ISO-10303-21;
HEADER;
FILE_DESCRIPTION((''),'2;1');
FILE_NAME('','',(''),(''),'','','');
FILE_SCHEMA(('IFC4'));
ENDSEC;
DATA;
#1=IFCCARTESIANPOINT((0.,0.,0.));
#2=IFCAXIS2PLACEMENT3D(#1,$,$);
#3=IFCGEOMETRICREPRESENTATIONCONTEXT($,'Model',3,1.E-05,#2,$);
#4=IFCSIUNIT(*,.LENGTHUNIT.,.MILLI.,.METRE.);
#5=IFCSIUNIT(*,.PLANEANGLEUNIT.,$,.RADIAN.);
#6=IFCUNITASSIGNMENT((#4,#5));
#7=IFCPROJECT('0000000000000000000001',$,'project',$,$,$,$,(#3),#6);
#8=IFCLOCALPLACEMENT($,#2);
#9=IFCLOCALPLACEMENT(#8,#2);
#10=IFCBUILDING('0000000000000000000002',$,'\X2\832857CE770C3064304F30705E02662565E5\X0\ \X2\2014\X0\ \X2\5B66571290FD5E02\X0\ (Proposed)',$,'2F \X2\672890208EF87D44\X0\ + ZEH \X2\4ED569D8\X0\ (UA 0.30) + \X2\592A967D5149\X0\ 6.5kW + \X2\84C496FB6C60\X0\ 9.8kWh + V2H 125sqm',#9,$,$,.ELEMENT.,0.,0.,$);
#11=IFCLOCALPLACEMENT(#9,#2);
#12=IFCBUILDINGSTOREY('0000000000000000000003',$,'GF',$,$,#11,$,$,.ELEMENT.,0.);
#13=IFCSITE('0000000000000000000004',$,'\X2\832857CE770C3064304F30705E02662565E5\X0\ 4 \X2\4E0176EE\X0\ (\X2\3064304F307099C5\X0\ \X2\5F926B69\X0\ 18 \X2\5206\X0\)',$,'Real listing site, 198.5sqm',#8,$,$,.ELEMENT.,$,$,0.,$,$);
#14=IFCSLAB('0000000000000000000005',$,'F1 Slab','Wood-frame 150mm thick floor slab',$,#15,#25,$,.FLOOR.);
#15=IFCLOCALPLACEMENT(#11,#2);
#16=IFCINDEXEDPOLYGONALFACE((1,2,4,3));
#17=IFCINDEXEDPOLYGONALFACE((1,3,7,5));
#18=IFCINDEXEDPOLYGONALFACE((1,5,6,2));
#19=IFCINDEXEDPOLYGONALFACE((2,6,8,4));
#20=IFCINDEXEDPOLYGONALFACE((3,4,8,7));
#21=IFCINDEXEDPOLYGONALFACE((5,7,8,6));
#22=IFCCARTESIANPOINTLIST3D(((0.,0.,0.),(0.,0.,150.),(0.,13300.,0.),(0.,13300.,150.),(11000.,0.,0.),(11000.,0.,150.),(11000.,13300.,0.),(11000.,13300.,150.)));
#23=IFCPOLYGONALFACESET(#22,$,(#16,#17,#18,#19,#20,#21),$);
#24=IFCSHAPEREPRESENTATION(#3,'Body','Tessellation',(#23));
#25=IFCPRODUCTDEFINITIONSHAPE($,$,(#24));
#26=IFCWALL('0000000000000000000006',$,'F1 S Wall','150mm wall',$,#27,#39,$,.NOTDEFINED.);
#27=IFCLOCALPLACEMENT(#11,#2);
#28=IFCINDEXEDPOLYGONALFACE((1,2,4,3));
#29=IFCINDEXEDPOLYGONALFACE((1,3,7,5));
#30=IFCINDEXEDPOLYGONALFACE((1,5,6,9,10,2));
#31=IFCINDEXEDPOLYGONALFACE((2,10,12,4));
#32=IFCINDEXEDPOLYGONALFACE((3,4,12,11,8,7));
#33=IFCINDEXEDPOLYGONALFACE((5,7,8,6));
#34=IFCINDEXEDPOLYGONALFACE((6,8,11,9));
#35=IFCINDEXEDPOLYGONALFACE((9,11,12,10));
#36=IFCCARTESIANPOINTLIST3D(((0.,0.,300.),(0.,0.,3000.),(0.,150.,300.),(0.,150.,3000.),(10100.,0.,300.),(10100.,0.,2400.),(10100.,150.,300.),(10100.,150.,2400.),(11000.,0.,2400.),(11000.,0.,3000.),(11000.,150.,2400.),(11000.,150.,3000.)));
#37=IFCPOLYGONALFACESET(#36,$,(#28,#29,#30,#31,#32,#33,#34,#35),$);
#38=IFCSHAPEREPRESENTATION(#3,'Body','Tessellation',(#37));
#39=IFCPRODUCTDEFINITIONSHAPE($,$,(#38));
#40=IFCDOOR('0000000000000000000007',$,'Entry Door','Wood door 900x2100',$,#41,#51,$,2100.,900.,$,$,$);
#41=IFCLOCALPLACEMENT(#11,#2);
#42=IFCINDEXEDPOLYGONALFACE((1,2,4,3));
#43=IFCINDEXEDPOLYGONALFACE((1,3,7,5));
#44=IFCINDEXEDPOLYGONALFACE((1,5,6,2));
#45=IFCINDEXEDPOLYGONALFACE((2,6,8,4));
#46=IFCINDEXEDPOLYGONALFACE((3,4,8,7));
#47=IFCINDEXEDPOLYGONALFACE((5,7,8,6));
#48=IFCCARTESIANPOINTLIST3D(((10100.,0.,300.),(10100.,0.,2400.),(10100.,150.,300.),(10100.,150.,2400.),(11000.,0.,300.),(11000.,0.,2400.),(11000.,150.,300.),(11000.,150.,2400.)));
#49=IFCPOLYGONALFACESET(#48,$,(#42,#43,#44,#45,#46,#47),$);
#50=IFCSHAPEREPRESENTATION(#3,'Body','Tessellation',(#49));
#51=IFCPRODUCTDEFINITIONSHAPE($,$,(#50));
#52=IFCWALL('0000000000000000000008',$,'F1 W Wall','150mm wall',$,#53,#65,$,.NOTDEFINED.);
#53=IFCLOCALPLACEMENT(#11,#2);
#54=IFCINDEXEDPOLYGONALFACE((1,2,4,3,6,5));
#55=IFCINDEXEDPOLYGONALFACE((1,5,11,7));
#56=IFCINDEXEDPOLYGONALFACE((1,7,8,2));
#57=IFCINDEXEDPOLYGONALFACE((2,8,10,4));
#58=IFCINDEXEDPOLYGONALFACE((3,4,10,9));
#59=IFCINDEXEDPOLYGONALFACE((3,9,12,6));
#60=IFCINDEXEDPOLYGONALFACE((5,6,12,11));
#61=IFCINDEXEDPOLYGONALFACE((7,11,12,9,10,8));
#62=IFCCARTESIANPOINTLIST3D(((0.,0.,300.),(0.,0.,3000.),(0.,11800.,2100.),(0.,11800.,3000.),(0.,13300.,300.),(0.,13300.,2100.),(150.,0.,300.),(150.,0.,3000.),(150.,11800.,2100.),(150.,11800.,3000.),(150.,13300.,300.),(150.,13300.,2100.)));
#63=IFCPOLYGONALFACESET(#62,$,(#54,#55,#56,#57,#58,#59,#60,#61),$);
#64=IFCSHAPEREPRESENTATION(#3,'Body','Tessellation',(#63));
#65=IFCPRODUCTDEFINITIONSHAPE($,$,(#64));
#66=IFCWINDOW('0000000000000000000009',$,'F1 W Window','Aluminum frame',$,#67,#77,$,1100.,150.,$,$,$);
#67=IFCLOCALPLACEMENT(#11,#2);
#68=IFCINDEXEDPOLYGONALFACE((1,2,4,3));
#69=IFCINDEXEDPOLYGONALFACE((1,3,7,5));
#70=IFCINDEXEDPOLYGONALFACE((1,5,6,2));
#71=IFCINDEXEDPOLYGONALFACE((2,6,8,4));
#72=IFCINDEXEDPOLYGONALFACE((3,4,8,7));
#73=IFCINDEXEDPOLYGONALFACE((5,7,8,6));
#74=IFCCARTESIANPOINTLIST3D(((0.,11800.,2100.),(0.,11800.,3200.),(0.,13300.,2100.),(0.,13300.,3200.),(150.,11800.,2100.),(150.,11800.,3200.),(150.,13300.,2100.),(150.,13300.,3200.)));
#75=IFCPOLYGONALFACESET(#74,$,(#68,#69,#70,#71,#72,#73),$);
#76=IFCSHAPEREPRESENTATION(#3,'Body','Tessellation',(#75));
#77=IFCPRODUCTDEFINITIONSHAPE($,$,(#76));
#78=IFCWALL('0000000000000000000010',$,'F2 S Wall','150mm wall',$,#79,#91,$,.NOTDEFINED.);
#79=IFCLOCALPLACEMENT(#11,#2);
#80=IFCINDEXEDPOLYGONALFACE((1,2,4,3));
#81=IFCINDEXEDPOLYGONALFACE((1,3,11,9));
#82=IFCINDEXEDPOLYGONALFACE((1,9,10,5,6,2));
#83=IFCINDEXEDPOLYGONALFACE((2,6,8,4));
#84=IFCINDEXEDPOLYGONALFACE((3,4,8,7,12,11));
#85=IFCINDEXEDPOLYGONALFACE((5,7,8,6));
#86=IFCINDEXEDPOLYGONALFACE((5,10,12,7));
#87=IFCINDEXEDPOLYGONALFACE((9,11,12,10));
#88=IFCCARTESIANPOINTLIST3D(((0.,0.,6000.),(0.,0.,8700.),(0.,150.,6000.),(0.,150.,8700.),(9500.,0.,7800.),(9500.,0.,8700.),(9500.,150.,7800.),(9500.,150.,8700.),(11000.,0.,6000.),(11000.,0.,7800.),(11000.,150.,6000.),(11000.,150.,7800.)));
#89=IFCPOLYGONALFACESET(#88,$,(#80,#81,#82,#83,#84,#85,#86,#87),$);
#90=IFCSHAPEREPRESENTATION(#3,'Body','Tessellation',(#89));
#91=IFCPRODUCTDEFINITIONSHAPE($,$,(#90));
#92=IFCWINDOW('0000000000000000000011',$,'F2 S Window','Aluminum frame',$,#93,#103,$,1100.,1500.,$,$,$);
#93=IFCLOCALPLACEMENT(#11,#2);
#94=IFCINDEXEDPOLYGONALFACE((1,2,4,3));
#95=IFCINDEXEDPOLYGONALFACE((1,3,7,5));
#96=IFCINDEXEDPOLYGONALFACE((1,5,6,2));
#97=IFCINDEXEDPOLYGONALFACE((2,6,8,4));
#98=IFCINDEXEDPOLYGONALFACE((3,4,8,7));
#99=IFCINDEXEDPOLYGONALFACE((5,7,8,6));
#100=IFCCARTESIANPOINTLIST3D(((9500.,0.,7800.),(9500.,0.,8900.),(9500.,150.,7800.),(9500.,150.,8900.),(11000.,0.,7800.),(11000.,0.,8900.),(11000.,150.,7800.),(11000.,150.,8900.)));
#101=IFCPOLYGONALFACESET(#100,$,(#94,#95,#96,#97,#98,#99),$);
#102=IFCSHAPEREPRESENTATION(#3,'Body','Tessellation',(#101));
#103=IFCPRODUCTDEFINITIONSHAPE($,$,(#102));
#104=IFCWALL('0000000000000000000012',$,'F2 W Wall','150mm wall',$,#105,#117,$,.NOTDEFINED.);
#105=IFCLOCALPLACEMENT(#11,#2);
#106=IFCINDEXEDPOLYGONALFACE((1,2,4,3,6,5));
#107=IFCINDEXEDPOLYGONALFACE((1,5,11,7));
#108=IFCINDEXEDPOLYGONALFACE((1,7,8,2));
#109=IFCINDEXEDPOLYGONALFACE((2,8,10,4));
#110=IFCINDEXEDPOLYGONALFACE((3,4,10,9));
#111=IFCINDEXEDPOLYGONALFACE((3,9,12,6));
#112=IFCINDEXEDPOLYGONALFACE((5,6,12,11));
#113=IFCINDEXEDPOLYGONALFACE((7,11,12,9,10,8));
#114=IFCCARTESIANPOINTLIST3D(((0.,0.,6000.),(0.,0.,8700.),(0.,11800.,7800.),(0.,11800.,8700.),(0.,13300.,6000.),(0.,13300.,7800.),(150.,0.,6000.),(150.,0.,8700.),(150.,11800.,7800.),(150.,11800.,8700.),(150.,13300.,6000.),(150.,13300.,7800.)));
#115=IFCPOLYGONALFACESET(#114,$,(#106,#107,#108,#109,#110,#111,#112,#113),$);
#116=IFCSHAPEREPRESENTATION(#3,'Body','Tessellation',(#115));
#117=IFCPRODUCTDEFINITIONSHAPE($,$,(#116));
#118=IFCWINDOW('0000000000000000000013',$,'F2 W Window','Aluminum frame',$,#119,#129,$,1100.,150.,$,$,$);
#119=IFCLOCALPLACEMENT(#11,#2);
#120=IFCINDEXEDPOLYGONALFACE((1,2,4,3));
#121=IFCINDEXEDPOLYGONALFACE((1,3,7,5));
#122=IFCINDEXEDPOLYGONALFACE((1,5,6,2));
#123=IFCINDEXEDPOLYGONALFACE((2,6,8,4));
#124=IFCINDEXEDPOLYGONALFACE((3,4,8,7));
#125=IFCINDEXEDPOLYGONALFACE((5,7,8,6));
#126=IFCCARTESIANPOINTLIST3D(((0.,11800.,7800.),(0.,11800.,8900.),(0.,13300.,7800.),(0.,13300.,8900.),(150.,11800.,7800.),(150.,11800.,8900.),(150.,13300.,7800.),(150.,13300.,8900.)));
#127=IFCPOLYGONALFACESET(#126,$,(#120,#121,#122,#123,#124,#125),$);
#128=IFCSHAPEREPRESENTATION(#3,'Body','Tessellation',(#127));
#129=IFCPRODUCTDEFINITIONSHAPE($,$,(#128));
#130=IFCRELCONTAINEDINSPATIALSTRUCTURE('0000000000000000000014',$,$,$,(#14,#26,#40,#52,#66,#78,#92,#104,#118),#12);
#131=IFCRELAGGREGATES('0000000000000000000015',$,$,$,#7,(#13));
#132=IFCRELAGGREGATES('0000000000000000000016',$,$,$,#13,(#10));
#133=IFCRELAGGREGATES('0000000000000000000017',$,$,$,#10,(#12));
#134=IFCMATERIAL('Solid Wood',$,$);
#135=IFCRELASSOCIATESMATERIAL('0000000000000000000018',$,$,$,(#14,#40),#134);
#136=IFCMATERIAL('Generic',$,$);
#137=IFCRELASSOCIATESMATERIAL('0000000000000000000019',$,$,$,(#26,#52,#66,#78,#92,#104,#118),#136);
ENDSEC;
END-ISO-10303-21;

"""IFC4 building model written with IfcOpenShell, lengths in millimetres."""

from ifc_helpers import new_model, si_unit, frame, frame_2d, origin, place, context, project, spatial, rectangle, extrude, material, element, fill, save


model = new_model("IFC4")

# Units and contexts
model_context = context("Model", 3, precision=1e-05, world=origin())
ifc_project = project(units=[si_unit("LENGTHUNIT", "METRE", prefix="MILLI"), si_unit("PLANEANGLEUNIT", "RADIAN")], contexts=[model_context])

# Site, building, storey
site_placement = place(None, origin())
site = spatial("IfcSite", under=ifc_project, at=site_placement, Name="茨城県つくば市春日 4 丁目 (つくば駅 徒歩 18 分)", ObjectType="Real listing site, 198.5sqm", CompositionType="ELEMENT", RefElevation=0.0)
building_placement = place(site_placement, origin())
building = spatial("IfcBuilding", under=site, at=building_placement, Name="茨城県つくば市春日 — 学園都市 (Proposed)", ObjectType="2F 木造軸組 + ZEH 仕様 (UA 0.30) + 太陽光 6.5kW + 蓄電池 9.8kWh + V2H 125sqm", CompositionType="ELEMENT", ElevationOfRefHeight=0.0, ElevationOfTerrain=0.0)
storey_placement = place(building_placement, origin())
storey = spatial("IfcBuildingStorey", under=building, at=storey_placement, Name="GF", CompositionType="ELEMENT", Elevation=0.0)

# Slab
ifc_material_1 = material(Name="Solid Wood")
slab_1_placement = place(storey_placement, origin())
element("IfcSlab", 1, at=slab_1_placement, inside=storey, material=ifc_material_1, Name="F1 Slab", Description="Wood-frame 150mm thick floor slab", PredefinedType="FLOOR", context=model_context, shape_type="SweptSolid", body=[
    extrude(rectangle(XDim=11000.0, YDim=13300.0, at=frame_2d((5500.0, 6650.0))), origin(), (0.0, 0.0, 1.0), 150.0),
])

# Shared definitions
ifc_material_2 = material(Name="Generic")

# Wall, opening, door
wall_1_placement = place(storey_placement, frame((0.0, 0.0, 150.0)))
wall_1 = element("IfcWall", 2, at=wall_1_placement, inside=storey, material=ifc_material_2, Name="F1 S Wall", Description="150mm wall", PredefinedType="NOTDEFINED", context=model_context, shape_type="SweptSolid", body=[
    extrude(rectangle(XDim=11000.0, YDim=150.0, at=frame_2d((5500.0, 75.0))), frame((0.0, 0.0, 150.0)), (0.0, 0.0, 1.0), 2700.0),
])
opening_1_placement = place(storey_placement, frame((5050.0, 0.0, 150.0)))
opening_1 = element("IfcOpeningElement", 3, at=opening_1_placement, cuts=wall_1, PredefinedType="NOTDEFINED", context=model_context, shape_type="SweptSolid", body=[
    extrude(rectangle(XDim=900.0, YDim=150.0, at=frame_2d((450.0, 75.0))), frame((5050.0, 0.0, 150.0)), (0.0, 0.0, 1.0), 2100.0),
])
door_placement = place(storey_placement, frame((5050.0, 0.0, 150.0)))
door = element("IfcDoor", 4, at=door_placement, inside=storey, material=ifc_material_1, Name="Entry Door", Description="Wood door 900x2100", OverallHeight=2100.0, OverallWidth=900.0, context=model_context, shape_type="SweptSolid", body=[
    extrude(rectangle(XDim=900.0, YDim=150.0, at=frame_2d((450.0, 75.0))), frame((5050.0, 0.0, 150.0)), (0.0, 0.0, 1.0), 2100.0),
])
fill(opening_1, door)

# Walls, openings, windows
wall_2_placement = place(storey_placement, frame((0.0, 0.0, 150.0)))
wall_2 = element("IfcWall", 5, at=wall_2_placement, inside=storey, material=ifc_material_2, Name="F1 W Wall", Description="150mm wall", PredefinedType="NOTDEFINED", context=model_context, shape_type="SweptSolid", body=[
    extrude(rectangle(XDim=150.0, YDim=13300.0, at=frame_2d((75.0, 6650.0))), frame((0.0, 0.0, 150.0)), (0.0, 0.0, 1.0), 2700.0),
])
opening_2_placement = place(storey_placement, frame((0.0, 5900.0, 1050.0)))
opening_2 = element("IfcOpeningElement", 6, at=opening_2_placement, cuts=wall_2, PredefinedType="NOTDEFINED", context=model_context, shape_type="SweptSolid", body=[
    extrude(rectangle(XDim=150.0, YDim=1500.0, at=frame_2d((75.0, 750.0))), frame((0.0, 5900.0, 1050.0)), (0.0, 0.0, 1.0), 1100.0),
])
window_1_placement = place(storey_placement, frame((0.0, 5900.0, 1050.0)))
window_1 = element("IfcWindow", 7, at=window_1_placement, inside=storey, material=ifc_material_2, Name="F1 W Window", Description="Aluminum frame", OverallHeight=1100.0, OverallWidth=150.0, context=model_context, shape_type="SweptSolid", body=[
    extrude(rectangle(XDim=150.0, YDim=1500.0, at=frame_2d((75.0, 750.0))), frame((0.0, 5900.0, 1050.0)), (0.0, 0.0, 1.0), 1100.0),
])
fill(opening_2, window_1)
wall_3_placement = place(storey_placement, frame((0.0, 0.0, 3000.0)))
wall_3 = element("IfcWall", 8, at=wall_3_placement, inside=storey, material=ifc_material_2, Name="F2 S Wall", Description="150mm wall", PredefinedType="NOTDEFINED", context=model_context, shape_type="SweptSolid", body=[
    extrude(rectangle(XDim=11000.0, YDim=150.0, at=frame_2d((5500.0, 75.0))), frame((0.0, 0.0, 3000.0)), (0.0, 0.0, 1.0), 2700.0),
])
opening_3_placement = place(storey_placement, frame((4750.0, 0.0, 3900.0)))
opening_3 = element("IfcOpeningElement", 9, at=opening_3_placement, cuts=wall_3, PredefinedType="NOTDEFINED", context=model_context, shape_type="SweptSolid", body=[
    extrude(rectangle(XDim=1500.0, YDim=150.0, at=frame_2d((750.0, 75.0))), frame((4750.0, 0.0, 3900.0)), (0.0, 0.0, 1.0), 1100.0),
])
window_2_placement = place(storey_placement, frame((4750.0, 0.0, 3900.0)))
window_2 = element("IfcWindow", 10, at=window_2_placement, inside=storey, material=ifc_material_2, Name="F2 S Window", Description="Aluminum frame", OverallHeight=1100.0, OverallWidth=1500.0, context=model_context, shape_type="SweptSolid", body=[
    extrude(rectangle(XDim=1500.0, YDim=150.0, at=frame_2d((750.0, 75.0))), frame((4750.0, 0.0, 3900.0)), (0.0, 0.0, 1.0), 1100.0),
])
fill(opening_3, window_2)
wall_4_placement = place(storey_placement, frame((0.0, 0.0, 3000.0)))
wall_4 = element("IfcWall", 11, at=wall_4_placement, inside=storey, material=ifc_material_2, Name="F2 W Wall", Description="150mm wall", PredefinedType="NOTDEFINED", context=model_context, shape_type="SweptSolid", body=[
    extrude(rectangle(XDim=150.0, YDim=13300.0, at=frame_2d((75.0, 6650.0))), frame((0.0, 0.0, 3000.0)), (0.0, 0.0, 1.0), 2700.0),
])
opening_4_placement = place(storey_placement, frame((0.0, 5900.0, 3900.0)))
opening_4 = element("IfcOpeningElement", 12, at=opening_4_placement, cuts=wall_4, PredefinedType="NOTDEFINED", context=model_context, shape_type="SweptSolid", body=[
    extrude(rectangle(XDim=150.0, YDim=1500.0, at=frame_2d((75.0, 750.0))), frame((0.0, 5900.0, 3900.0)), (0.0, 0.0, 1.0), 1100.0),
])
window_3_placement = place(storey_placement, frame((0.0, 5900.0, 3900.0)))
window_3 = element("IfcWindow", 13, at=window_3_placement, inside=storey, material=ifc_material_2, Name="F2 W Window", Description="Aluminum frame", OverallHeight=1100.0, OverallWidth=150.0, context=model_context, shape_type="SweptSolid", body=[
    extrude(rectangle(XDim=150.0, YDim=1500.0, at=frame_2d((75.0, 750.0))), frame((0.0, 5900.0, 3900.0)), (0.0, 0.0, 1.0), 1100.0),
])
fill(opening_4, window_3)

save(model, "model.ifc")
